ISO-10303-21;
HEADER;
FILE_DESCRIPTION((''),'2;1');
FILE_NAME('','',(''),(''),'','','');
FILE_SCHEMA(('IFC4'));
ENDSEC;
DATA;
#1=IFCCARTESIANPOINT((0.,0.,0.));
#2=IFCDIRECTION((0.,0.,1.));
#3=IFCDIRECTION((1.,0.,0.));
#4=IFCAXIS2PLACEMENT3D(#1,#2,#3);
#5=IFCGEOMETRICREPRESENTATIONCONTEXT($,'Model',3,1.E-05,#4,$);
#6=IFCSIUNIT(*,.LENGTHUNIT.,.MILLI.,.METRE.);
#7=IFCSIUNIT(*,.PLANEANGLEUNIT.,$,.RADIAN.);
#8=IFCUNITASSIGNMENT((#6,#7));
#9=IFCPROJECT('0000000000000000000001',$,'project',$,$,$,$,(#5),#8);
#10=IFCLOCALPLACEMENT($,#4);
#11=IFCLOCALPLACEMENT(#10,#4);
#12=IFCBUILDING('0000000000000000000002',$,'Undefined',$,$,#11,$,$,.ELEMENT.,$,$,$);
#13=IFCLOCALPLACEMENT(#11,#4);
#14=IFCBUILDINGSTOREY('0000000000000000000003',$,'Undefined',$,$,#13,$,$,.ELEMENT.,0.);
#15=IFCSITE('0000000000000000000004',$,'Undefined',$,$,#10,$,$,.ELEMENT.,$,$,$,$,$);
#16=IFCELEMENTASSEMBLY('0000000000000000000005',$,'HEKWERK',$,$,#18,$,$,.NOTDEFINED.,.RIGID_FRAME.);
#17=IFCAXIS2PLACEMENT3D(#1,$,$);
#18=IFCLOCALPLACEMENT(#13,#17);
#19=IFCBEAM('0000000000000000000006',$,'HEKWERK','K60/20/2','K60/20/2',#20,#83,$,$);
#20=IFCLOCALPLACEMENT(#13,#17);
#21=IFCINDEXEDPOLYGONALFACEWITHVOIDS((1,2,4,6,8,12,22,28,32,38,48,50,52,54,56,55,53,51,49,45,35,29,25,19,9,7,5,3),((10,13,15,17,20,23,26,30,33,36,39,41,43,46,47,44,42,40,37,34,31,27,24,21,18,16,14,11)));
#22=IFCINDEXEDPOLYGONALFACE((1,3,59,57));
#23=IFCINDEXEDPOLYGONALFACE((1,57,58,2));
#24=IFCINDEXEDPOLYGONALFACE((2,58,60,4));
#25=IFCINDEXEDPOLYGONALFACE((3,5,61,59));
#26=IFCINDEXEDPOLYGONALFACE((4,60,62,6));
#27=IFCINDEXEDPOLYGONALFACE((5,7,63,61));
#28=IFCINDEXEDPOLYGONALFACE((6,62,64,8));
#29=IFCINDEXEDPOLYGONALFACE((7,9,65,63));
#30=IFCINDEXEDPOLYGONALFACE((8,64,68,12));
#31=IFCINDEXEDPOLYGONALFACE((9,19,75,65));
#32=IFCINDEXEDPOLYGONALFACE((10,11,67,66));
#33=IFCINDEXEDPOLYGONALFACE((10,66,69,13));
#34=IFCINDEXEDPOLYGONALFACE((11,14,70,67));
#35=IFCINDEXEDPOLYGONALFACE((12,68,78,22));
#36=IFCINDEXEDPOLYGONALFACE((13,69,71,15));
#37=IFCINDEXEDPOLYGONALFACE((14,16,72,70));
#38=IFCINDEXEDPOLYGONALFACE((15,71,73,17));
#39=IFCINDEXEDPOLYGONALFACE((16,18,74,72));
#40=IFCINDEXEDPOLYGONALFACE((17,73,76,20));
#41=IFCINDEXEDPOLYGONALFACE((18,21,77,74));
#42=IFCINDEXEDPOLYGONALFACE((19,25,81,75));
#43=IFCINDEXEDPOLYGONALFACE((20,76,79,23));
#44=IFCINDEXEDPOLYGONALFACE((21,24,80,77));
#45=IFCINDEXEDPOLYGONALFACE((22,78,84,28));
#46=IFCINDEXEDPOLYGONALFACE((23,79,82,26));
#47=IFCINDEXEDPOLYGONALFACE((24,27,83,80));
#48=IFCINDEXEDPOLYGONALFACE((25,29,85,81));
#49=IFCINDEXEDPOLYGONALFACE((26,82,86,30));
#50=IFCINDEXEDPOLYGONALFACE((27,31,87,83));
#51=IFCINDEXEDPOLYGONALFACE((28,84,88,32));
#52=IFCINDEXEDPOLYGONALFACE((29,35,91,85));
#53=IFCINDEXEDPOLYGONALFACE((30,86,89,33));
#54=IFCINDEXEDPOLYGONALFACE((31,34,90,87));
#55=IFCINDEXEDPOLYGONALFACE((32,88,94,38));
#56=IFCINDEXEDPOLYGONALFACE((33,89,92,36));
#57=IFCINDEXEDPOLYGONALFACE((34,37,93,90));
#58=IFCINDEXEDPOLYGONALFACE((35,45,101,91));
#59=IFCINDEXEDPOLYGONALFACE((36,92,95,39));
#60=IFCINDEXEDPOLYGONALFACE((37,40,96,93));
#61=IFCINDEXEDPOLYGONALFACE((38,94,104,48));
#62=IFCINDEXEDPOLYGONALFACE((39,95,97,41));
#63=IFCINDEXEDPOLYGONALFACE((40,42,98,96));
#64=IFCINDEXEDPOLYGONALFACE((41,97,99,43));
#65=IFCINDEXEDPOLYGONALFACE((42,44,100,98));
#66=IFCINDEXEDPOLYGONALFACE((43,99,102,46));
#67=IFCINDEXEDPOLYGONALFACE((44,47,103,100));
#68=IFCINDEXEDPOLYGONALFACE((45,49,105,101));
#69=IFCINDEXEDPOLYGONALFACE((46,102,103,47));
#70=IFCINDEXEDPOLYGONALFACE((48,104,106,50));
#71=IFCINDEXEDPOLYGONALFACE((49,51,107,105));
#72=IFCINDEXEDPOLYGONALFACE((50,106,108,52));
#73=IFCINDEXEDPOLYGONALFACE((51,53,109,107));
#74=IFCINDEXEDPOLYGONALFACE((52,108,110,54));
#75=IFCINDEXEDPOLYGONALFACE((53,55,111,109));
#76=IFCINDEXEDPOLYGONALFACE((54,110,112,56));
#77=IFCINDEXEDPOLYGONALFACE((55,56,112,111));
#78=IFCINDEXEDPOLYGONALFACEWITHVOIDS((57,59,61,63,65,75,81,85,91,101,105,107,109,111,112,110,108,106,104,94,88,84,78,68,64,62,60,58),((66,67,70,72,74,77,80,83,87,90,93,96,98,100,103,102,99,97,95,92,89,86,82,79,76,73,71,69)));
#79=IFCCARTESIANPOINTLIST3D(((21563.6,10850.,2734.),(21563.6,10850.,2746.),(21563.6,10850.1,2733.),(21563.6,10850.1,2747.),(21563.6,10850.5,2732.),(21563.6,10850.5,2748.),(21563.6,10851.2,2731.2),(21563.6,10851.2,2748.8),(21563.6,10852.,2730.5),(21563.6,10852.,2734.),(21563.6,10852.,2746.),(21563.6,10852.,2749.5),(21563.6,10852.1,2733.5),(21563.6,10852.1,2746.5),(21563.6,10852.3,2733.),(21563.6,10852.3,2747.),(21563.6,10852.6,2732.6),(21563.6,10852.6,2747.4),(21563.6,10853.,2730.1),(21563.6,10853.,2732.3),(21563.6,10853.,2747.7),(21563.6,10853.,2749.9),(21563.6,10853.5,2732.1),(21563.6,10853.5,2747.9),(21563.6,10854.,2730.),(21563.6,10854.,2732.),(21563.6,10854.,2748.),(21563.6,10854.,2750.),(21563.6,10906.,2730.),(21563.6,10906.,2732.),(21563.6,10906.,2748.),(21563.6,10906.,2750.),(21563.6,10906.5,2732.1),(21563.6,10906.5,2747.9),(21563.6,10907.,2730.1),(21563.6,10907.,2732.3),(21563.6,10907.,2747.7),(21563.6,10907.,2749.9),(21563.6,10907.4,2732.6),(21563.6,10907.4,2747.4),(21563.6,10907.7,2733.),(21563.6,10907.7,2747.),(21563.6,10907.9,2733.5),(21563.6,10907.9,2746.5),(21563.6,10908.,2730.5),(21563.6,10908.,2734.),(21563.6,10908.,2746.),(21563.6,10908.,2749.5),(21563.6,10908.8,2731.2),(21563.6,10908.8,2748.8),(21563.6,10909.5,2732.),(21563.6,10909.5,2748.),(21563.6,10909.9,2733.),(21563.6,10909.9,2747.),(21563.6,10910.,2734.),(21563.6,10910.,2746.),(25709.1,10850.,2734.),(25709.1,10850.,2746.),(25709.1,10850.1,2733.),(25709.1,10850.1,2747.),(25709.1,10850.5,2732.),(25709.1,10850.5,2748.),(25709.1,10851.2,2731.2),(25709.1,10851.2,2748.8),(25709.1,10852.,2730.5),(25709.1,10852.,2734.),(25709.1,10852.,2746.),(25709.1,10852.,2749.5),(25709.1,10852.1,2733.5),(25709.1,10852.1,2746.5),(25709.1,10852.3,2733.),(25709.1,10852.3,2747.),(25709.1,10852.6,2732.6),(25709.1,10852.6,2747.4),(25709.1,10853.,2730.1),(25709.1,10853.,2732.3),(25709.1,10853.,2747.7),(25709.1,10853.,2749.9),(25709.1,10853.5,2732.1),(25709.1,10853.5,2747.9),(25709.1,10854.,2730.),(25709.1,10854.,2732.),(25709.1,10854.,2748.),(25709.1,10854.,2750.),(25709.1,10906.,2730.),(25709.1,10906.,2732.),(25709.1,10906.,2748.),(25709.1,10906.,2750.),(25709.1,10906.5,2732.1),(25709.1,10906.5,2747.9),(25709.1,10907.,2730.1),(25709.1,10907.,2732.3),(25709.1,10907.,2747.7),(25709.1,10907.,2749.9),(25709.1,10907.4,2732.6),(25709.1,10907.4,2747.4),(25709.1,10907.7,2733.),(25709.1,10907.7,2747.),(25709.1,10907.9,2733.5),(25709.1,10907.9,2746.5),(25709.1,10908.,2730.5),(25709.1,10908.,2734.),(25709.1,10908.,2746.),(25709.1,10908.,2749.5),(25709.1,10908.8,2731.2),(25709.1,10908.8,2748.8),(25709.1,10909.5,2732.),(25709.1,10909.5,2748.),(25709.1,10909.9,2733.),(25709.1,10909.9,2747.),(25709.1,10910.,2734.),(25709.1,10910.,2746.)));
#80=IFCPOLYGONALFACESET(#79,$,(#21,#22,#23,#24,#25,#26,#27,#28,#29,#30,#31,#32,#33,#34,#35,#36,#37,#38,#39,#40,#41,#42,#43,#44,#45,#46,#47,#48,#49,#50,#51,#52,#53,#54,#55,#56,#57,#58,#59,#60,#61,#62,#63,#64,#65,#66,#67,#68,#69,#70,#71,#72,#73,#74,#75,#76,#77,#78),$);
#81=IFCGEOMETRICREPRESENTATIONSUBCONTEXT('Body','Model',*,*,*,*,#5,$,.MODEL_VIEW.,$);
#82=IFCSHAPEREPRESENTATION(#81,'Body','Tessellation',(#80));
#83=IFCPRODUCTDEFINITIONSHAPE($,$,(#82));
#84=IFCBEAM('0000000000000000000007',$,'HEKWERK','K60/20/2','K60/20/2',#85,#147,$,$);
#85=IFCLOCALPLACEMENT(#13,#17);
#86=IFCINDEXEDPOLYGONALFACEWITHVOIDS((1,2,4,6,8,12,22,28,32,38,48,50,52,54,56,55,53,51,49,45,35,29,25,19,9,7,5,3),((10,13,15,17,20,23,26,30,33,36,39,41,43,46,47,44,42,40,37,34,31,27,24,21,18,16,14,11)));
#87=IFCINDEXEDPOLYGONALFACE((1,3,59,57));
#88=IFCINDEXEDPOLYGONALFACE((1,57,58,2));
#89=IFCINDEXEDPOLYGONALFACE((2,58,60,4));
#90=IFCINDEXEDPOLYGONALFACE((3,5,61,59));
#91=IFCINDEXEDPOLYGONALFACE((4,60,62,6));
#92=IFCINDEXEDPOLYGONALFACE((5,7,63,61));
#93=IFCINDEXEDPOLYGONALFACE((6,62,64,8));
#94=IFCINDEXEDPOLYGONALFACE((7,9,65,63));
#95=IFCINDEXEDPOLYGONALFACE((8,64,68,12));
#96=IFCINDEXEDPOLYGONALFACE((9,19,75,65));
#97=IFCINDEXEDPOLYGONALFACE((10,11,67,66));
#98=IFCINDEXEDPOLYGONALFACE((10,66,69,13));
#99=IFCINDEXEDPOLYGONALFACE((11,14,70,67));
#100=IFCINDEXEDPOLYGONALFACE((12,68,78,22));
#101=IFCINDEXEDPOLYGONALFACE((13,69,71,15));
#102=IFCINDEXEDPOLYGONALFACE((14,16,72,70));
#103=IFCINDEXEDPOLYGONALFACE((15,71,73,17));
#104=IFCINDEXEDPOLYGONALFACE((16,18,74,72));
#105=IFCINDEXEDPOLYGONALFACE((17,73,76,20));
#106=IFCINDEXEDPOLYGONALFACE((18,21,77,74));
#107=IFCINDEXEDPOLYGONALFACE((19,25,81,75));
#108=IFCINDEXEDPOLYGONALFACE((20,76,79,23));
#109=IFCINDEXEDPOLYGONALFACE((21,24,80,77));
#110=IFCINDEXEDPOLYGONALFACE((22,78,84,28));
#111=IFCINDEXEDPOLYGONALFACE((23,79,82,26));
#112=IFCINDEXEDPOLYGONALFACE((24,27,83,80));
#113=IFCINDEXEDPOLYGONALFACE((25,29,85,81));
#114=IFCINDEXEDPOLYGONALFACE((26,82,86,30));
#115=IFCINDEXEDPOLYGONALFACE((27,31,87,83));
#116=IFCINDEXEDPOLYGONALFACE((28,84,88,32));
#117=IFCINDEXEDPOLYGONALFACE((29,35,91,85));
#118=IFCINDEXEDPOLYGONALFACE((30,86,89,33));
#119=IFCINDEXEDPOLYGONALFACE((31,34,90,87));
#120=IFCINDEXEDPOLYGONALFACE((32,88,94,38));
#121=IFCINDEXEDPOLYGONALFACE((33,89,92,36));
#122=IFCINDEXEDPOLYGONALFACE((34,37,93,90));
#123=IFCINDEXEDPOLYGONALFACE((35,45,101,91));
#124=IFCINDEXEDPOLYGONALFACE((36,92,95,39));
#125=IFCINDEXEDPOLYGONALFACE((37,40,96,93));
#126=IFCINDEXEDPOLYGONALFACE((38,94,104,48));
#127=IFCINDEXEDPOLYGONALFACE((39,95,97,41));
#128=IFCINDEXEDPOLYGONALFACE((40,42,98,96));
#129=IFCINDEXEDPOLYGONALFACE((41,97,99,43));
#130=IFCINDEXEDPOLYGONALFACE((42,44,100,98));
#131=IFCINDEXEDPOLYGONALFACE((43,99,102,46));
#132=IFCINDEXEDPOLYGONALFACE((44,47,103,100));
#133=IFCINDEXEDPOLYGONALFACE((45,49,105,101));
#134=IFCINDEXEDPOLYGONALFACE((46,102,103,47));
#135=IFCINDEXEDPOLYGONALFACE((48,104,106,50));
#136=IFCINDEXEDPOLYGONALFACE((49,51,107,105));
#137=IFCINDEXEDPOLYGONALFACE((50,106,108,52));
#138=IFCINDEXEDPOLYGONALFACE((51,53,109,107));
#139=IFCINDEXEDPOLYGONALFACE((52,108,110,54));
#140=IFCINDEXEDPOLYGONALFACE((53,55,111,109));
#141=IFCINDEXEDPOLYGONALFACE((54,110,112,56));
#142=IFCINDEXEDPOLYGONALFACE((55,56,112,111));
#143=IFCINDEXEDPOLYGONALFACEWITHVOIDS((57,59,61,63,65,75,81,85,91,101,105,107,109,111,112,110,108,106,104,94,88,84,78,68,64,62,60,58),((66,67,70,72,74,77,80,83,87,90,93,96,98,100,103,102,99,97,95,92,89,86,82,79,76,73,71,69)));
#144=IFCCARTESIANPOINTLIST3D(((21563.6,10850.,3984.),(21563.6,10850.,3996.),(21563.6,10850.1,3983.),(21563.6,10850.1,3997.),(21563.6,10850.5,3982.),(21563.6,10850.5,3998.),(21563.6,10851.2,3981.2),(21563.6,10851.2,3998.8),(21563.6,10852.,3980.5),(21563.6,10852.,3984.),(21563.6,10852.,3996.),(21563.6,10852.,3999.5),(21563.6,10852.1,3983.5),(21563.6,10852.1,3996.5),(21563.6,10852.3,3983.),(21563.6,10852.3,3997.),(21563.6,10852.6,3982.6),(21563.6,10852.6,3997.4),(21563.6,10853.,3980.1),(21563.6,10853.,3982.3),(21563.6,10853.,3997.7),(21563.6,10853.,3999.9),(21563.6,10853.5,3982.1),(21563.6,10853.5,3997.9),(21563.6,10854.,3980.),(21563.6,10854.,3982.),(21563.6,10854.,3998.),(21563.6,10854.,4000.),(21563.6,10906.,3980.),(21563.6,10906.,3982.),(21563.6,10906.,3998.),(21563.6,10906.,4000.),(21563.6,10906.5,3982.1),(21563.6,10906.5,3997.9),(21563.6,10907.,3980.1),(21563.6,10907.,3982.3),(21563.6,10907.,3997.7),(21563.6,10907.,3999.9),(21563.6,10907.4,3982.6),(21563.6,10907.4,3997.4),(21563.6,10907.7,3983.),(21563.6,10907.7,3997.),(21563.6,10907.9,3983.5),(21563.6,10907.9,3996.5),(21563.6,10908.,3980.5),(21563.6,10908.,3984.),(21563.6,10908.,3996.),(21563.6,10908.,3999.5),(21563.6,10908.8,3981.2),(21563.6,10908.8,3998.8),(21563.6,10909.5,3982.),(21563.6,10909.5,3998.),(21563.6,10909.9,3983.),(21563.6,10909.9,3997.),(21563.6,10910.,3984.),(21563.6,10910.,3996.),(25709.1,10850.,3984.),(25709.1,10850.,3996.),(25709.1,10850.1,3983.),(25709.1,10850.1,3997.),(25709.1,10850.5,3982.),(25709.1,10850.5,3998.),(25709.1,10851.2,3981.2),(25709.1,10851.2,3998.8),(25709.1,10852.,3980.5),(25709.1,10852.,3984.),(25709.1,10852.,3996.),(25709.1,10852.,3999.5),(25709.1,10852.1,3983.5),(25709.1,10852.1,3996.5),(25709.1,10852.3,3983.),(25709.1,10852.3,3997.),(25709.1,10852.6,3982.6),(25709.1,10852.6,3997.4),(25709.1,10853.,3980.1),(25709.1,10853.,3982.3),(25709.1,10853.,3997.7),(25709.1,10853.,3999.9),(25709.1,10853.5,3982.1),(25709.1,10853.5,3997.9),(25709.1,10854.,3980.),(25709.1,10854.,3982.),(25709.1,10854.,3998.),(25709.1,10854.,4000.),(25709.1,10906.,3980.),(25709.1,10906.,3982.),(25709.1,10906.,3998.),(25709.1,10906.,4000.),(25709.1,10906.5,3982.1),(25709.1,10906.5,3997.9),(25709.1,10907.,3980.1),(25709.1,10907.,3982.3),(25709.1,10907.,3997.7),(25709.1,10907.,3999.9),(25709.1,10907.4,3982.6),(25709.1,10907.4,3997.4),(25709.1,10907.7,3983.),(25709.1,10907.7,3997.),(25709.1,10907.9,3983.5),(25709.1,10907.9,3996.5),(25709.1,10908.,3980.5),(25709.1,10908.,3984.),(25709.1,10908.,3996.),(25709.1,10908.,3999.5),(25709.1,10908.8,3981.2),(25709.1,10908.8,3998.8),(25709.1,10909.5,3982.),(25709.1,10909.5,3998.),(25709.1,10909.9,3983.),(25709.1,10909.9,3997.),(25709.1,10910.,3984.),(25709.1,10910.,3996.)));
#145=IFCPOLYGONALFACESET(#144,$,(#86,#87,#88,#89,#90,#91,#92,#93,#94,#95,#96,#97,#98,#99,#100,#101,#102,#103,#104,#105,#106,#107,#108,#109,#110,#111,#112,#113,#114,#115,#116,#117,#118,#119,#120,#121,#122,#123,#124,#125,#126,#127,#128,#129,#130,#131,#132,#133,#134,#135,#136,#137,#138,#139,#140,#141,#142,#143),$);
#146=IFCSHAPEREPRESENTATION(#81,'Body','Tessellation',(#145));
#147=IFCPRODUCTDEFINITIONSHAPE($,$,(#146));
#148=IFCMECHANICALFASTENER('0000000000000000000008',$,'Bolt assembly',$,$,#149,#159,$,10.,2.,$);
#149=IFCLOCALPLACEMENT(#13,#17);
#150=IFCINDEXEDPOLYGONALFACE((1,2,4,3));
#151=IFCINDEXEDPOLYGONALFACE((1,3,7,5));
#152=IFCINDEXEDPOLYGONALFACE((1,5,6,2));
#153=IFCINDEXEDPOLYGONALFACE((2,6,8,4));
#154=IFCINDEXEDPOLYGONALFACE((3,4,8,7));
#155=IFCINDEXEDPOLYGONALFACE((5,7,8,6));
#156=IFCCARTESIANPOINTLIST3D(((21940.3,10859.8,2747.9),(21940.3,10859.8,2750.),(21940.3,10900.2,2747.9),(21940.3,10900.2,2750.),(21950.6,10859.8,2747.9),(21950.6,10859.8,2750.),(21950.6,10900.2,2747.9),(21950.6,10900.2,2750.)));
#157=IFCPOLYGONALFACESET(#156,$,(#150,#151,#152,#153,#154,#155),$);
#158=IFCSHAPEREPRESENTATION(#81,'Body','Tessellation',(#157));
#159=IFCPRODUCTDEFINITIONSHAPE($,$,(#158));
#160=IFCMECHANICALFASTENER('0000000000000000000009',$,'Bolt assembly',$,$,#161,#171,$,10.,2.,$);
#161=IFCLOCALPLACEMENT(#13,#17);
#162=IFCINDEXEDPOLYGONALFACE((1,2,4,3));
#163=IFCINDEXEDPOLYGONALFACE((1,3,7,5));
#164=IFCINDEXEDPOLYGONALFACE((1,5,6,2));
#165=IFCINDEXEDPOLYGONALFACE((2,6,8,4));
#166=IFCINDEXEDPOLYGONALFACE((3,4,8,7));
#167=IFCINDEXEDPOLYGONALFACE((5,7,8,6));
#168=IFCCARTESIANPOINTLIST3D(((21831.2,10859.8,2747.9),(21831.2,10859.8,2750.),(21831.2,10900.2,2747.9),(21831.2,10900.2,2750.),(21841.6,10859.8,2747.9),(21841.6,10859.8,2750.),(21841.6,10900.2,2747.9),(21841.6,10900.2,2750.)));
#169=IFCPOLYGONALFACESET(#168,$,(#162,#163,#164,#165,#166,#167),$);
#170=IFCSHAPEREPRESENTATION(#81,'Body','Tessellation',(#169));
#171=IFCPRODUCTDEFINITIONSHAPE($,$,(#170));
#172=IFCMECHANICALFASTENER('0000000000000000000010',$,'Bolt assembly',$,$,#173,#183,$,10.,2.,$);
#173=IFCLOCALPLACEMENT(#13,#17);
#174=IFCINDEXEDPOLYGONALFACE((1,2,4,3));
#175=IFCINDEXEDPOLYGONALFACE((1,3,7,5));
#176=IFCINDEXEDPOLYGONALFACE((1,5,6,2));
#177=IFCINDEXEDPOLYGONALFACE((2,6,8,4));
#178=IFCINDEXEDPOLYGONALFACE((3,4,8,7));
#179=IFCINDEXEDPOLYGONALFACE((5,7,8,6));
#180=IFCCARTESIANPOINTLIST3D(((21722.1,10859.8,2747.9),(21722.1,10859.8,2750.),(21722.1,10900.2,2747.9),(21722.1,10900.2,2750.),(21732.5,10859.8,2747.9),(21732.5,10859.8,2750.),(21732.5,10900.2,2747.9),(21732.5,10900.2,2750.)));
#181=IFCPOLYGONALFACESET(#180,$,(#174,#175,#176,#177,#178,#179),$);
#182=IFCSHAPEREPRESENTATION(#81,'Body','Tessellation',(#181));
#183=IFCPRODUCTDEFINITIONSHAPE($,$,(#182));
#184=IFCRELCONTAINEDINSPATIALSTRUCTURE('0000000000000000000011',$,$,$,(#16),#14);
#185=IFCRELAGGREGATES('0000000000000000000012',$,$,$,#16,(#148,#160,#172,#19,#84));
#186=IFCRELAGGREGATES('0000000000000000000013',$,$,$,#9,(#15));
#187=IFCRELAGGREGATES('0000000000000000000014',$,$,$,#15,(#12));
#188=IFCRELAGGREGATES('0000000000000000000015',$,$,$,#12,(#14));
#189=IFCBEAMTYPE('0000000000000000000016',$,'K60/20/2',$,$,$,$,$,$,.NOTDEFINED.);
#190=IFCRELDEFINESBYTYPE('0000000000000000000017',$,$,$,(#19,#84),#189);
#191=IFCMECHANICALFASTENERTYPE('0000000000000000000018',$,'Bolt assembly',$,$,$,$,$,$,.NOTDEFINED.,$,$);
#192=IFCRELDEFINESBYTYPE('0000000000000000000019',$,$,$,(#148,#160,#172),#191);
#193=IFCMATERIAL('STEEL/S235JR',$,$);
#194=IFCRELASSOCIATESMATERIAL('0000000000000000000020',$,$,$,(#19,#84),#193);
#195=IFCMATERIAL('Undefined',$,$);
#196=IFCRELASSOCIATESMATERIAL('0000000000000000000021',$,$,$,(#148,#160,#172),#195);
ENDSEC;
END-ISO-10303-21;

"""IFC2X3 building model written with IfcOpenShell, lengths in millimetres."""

from ifc_helpers import new_model, si_unit, frame, origin_with_axes, origin_2d_with_axis, place, context, subcontext, project, spatial, polyline, segment, composite_curve, hollow_rectangle, outline, extrude, source, transform, mapped, material, type_object, element, aggregate, save


model = new_model("IFC2X3")

# Units and contexts
model_context = context("Model", 3, precision=1e-05, world=origin_with_axes())
body_context = subcontext(model_context, "Body", "Model", "MODEL_VIEW")
ifc_project = project(units=[si_unit("LENGTHUNIT", "METRE", prefix="MILLI"), si_unit("PLANEANGLEUNIT", "RADIAN")], contexts=[model_context])

# Site, building, storey
site_placement = place(None, origin_with_axes())
site = spatial("IfcSite", under=ifc_project, at=site_placement, Name="Undefined", CompositionType="ELEMENT")
building_placement = place(site_placement, origin_with_axes())
building = spatial("IfcBuilding", under=site, at=building_placement, Name="Undefined", CompositionType="ELEMENT")
storey_placement = place(building_placement, origin_with_axes())
storey = spatial("IfcBuildingStorey", under=building, at=storey_placement, Name="Undefined", CompositionType="ELEMENT", Elevation=0.0)

# Element assembly, beams
assembly_1_placement = place(storey_placement, origin_with_axes())
assembly_1 = element("IfcElementAssembly", 1, at=assembly_1_placement, inside=storey, Name="HEKWERK", AssemblyPlace="NOTDEFINED", PredefinedType="RIGID_FRAME")
ifc_material_1 = material(Name="STEEL/S235JR")
beam_type_1 = type_object("IfcBeamType", Name="K60/20/2", PredefinedType="NOTDEFINED")
beam_1_placement = place(assembly_1_placement, frame((21563.6, 10880.0, 2740.0), z_axis=(0.0, 1.0, 0.0), x_axis=(1.0, 0.0, 0.0)))
beam_1 = element("IfcBeam", 2, at=beam_1_placement, type_object=beam_type_1, material=ifc_material_1, Name="HEKWERK", Description="K60/20/2", ObjectType="K60/20/2", context=body_context, shape_type="SweptSolid", body=[
    extrude(hollow_rectangle(XDim=20.0, YDim=60.0, WallThickness=2.0, InnerFilletRadius=2.0, OuterFilletRadius=4.0, at=origin_2d_with_axis()), frame((4145.4, 0.0, 0.0), z_axis=(-1.0, 0.0, 0.0), x_axis=(0.0, -1.0, 0.0)), (0.0, 0.0, 1.0), 4145.4),
])
beam_2_placement = place(assembly_1_placement, frame((21563.6, 10880.0, 3990.0), z_axis=(0.0, 1.0, 0.0), x_axis=(1.0, 0.0, 0.0)))
beam_2 = element("IfcBeam", 3, at=beam_2_placement, type_object=beam_type_1, material=ifc_material_1, Name="HEKWERK", Description="K60/20/2", ObjectType="K60/20/2", context=body_context, shape_type="SweptSolid", body=[
    extrude(hollow_rectangle(XDim=20.0, YDim=60.0, WallThickness=2.0, InnerFilletRadius=2.0, OuterFilletRadius=4.0, at=origin_2d_with_axis()), frame((4145.4, 0.0, 0.0), z_axis=(-1.0, 0.0, 0.0), x_axis=(0.0, -1.0, 0.0)), (0.0, 0.0, 1.0), 4145.4),
])

# Mechanical fasteners
ifc_material_2 = material(Name="Undefined")
mechanical_fastener_type = type_object("IfcMechanicalFastenerType", Name="Bolt assembly")
shared_shape_1 = source(origin_with_axes(), body_context, "Body", "SweptSolid", [
    extrude(outline(composite_curve([segment(polyline([(-20.2, 5.2), (20.2, 5.2)]), True, "CONTINUOUS"), segment(polyline([(20.2, 5.2), (20.2, -5.2)]), True, "CONTINUOUS"), segment(polyline([(20.2, -5.2), (-20.2, -5.2)]), True, "CONTINUOUS"), segment(polyline([(-20.2, -5.2), (-20.2, 5.2)]), True, "CONTINUOUS")], self_intersect=False)), frame((0.0, -1.0, 0.0), z_axis=(0.0, 1.0, 0.0), x_axis=(1.0, 0.0, 0.0)), (0.0, 0.0, 1.0), 2.1),
])
mechanical_fastener_1_placement = place(assembly_1_placement, frame((21945.4, 10880.0, 2749.0), z_axis=(1.0, 0.0, 0.0), x_axis=(0.0, -1.0, 0.0)))
mechanical_fastener_1 = element("IfcMechanicalFastener", 4, at=mechanical_fastener_1_placement, type_object=mechanical_fastener_type, material=ifc_material_2, Name="Bolt assembly", NominalDiameter=10.0, NominalLength=2.0, context=body_context, shape_type="MappedRepresentation", body=[
    mapped(shared_shape_1, transform((0.0, 0.0, 0.0))),
])
shared_shape_2 = source(origin_with_axes(), body_context, "Body", "SweptSolid", [
    extrude(outline(composite_curve([segment(polyline([(-20.2, 5.2), (20.2, 5.2)]), True, "CONTINUOUS"), segment(polyline([(20.2, 5.2), (20.2, -5.2)]), True, "CONTINUOUS"), segment(polyline([(20.2, -5.2), (-20.2, -5.2)]), True, "CONTINUOUS"), segment(polyline([(-20.2, -5.2), (-20.2, 5.2)]), True, "CONTINUOUS")], self_intersect=False)), frame((0.0, -1.0, 0.0), z_axis=(0.0, 1.0, 0.0), x_axis=(1.0, 0.0, 0.0)), (0.0, 0.0, 1.0), 2.1),
])
mechanical_fastener_2_placement = place(assembly_1_placement, frame((21836.4, 10880.0, 2749.0), z_axis=(1.0, 0.0, 0.0), x_axis=(0.0, -1.0, 0.0)))
mechanical_fastener_2 = element("IfcMechanicalFastener", 5, at=mechanical_fastener_2_placement, type_object=mechanical_fastener_type, material=ifc_material_2, Name="Bolt assembly", NominalDiameter=10.0, NominalLength=2.0, context=body_context, shape_type="MappedRepresentation", body=[
    mapped(shared_shape_2, transform((0.0, 0.0, 0.0))),
])
shared_shape_3 = source(origin_with_axes(), body_context, "Body", "SweptSolid", [
    extrude(outline(composite_curve([segment(polyline([(-20.2, 5.2), (20.2, 5.2)]), True, "CONTINUOUS"), segment(polyline([(20.2, 5.2), (20.2, -5.2)]), True, "CONTINUOUS"), segment(polyline([(20.2, -5.2), (-20.2, -5.2)]), True, "CONTINUOUS"), segment(polyline([(-20.2, -5.2), (-20.2, 5.2)]), True, "CONTINUOUS")], self_intersect=False)), frame((0.0, -1.0, 0.0), z_axis=(0.0, 1.0, 0.0), x_axis=(1.0, 0.0, 0.0)), (0.0, 0.0, 1.0), 2.1),
])
mechanical_fastener_3_placement = place(assembly_1_placement, frame((21727.3, 10880.0, 2749.0), z_axis=(1.0, 0.0, 0.0), x_axis=(0.0, -1.0, 0.0)))
mechanical_fastener_3 = element("IfcMechanicalFastener", 6, at=mechanical_fastener_3_placement, type_object=mechanical_fastener_type, material=ifc_material_2, Name="Bolt assembly", NominalDiameter=10.0, NominalLength=2.0, context=body_context, shape_type="MappedRepresentation", body=[
    mapped(shared_shape_3, transform((0.0, 0.0, 0.0))),
])
aggregate(assembly_1, [mechanical_fastener_1, mechanical_fastener_2, mechanical_fastener_3, beam_1, beam_2])

save(model, "model.ifc")
